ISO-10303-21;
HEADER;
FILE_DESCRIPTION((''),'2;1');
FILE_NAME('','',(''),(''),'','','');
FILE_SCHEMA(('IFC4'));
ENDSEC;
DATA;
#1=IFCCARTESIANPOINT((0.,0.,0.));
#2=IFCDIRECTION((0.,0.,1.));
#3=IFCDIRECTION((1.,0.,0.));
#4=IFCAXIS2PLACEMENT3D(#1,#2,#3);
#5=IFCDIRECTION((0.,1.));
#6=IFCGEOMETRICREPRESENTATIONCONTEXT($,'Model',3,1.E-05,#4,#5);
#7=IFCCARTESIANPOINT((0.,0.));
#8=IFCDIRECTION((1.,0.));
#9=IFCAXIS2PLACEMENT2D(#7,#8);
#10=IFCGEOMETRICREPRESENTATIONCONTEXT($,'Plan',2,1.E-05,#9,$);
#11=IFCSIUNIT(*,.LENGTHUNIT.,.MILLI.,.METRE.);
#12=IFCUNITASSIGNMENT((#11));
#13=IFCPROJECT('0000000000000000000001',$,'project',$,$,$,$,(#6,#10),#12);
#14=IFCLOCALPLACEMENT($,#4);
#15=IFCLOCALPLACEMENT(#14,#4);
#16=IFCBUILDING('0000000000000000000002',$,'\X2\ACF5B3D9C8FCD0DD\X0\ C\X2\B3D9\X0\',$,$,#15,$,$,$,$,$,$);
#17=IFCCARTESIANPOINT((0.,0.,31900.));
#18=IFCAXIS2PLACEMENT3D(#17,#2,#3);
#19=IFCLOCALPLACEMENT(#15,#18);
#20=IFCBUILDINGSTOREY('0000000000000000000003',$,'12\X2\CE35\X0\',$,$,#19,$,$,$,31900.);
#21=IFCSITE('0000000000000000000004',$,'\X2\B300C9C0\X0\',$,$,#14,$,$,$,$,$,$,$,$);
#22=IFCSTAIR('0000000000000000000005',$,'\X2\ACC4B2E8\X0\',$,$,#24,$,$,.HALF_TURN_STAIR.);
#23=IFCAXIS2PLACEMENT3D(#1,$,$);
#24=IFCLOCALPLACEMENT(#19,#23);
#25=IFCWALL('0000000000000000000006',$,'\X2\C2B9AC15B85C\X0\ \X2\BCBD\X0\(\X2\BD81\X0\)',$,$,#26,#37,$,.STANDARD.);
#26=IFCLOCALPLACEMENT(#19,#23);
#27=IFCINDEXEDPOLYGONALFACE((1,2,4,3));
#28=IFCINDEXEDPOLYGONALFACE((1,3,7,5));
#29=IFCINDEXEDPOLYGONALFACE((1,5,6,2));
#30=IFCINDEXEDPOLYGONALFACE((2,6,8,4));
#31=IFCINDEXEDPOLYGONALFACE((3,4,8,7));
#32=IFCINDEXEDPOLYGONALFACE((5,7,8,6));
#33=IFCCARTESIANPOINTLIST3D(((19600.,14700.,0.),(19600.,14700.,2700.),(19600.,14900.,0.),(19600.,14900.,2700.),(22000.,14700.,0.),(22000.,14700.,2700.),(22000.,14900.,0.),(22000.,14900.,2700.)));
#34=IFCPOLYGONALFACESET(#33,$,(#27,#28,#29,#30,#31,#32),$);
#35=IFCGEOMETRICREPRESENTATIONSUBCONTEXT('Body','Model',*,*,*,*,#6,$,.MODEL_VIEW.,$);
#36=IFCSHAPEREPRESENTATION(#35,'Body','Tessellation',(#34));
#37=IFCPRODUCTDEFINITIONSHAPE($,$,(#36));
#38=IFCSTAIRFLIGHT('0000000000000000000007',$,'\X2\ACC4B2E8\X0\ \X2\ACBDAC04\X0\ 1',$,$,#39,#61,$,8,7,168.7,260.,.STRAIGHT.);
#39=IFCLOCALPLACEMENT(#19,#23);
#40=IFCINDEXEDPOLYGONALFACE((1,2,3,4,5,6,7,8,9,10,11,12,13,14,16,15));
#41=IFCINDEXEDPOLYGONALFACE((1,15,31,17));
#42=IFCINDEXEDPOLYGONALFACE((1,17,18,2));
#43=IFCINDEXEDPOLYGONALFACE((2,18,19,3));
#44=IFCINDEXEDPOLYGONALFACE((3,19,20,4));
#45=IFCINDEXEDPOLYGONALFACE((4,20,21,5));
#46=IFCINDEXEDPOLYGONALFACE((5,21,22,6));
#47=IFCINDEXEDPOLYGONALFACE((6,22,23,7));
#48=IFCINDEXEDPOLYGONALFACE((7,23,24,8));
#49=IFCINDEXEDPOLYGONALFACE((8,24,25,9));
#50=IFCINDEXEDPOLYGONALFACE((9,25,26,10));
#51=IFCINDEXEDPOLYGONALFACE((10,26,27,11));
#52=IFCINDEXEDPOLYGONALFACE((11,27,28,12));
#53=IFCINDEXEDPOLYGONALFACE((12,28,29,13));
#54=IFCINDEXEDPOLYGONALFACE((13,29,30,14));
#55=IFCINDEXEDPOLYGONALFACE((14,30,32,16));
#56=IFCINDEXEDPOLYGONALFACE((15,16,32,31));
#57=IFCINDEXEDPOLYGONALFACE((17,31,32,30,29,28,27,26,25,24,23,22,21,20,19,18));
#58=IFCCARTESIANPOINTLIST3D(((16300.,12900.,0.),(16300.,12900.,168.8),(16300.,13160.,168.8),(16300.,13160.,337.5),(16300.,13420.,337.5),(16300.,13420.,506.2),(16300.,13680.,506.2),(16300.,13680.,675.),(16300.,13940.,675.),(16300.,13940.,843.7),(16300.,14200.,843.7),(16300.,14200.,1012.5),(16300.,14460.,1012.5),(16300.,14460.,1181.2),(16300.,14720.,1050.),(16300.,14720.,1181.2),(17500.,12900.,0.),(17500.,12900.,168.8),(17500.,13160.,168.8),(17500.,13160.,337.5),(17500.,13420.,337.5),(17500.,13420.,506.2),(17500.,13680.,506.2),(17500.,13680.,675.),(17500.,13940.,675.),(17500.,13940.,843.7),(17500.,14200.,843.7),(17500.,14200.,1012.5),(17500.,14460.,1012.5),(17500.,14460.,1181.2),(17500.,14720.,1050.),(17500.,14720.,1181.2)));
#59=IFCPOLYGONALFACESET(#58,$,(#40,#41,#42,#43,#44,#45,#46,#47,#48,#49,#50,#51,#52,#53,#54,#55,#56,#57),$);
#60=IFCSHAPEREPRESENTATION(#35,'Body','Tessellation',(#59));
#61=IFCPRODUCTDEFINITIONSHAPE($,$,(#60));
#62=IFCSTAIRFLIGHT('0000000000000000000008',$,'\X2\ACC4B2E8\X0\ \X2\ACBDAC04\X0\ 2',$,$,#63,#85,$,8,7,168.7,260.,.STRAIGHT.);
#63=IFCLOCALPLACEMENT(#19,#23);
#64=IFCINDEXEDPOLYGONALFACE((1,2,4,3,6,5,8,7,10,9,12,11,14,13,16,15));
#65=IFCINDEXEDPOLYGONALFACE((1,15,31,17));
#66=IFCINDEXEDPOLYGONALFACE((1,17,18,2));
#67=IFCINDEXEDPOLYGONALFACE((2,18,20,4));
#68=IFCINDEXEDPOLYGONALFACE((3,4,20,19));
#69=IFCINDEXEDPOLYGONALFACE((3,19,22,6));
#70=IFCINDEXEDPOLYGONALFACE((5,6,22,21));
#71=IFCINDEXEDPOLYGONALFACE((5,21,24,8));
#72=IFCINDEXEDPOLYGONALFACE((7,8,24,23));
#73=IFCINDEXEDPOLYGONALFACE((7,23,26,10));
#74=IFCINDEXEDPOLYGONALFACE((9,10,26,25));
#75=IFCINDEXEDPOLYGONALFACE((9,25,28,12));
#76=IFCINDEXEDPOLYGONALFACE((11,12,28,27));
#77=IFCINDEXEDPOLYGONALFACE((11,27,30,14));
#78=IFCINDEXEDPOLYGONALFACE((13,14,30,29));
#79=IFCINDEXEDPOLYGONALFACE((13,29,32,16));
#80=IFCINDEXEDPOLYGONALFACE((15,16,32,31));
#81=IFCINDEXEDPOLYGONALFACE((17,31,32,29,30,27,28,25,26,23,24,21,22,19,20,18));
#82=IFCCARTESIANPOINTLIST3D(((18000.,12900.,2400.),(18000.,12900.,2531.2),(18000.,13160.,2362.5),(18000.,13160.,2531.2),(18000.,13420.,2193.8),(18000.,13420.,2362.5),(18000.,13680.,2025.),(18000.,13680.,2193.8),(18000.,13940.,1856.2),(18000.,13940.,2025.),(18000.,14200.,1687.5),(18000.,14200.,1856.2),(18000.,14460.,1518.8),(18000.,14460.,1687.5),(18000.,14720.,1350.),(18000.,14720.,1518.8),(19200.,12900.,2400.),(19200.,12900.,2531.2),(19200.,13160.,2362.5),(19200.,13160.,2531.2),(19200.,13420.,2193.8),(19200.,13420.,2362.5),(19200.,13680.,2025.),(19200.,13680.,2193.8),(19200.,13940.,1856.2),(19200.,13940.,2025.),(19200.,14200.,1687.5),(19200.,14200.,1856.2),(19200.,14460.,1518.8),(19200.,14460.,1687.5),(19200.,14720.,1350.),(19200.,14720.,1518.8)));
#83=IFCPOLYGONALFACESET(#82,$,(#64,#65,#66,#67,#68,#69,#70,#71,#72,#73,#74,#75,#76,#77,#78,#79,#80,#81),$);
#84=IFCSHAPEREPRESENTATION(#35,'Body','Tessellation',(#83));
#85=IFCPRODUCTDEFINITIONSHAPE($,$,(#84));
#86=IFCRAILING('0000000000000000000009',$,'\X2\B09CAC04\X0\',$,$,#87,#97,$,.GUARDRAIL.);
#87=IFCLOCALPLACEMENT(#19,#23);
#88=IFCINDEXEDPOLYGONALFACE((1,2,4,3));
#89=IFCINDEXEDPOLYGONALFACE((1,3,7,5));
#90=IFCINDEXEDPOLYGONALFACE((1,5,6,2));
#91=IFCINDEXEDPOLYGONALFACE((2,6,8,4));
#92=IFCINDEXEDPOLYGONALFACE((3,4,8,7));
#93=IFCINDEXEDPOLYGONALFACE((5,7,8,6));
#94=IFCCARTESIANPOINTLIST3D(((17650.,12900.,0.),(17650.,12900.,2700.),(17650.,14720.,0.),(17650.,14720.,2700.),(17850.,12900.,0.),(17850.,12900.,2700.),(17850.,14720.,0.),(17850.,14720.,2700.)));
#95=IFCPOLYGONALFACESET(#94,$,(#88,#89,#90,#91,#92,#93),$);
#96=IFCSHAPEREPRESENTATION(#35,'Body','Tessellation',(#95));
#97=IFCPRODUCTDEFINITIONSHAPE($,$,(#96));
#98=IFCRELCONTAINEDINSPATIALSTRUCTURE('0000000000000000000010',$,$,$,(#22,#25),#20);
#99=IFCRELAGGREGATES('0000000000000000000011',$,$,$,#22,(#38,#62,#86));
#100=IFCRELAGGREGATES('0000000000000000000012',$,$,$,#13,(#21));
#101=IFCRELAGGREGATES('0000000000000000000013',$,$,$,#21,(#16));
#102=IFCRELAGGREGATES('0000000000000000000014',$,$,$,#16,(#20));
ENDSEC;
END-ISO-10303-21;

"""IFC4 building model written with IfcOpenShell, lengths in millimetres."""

from ifc_helpers import new_model, si_unit, direction, frame, origin_with_axes, origin_2d_with_axis, place, context, subcontext, project, spatial, polyline, outline, extrude, element, aggregate, save


model = new_model("IFC4")

# Units and contexts
model_context = context("Model", 3, precision=1e-05, world=origin_with_axes(), true_north=direction((0.0, 1.0)))
plan_context = context("Plan", 2, precision=1e-05, world=origin_2d_with_axis())
body_context = subcontext(model_context, "Body", "Model", "MODEL_VIEW")
ifc_project = project(units=[si_unit("LENGTHUNIT", "METRE", prefix="MILLI")], contexts=[model_context, plan_context])

# Site, building, storey
site_placement = place(None, origin_with_axes())
site = spatial("IfcSite", under=ifc_project, at=site_placement, Name="대지")
building_placement = place(site_placement, origin_with_axes())
building = spatial("IfcBuilding", under=site, at=building_placement, Name="공동주택 C동")
storey_placement = place(building_placement, frame((0.0, 0.0, 31900.0), z_axis=(0.0, 0.0, 1.0), x_axis=(1.0, 0.0, 0.0)))
storey = spatial("IfcBuildingStorey", under=building, at=storey_placement, Name="12층", Elevation=31900.0)

# Stair
stair_placement = place(storey_placement, origin_with_axes())
stair = element("IfcStair", 1, at=stair_placement, inside=storey, Name="계단", PredefinedType="HALF_TURN_STAIR")

# Wall
wall_1_placement = place(storey_placement, origin_with_axes())
element("IfcWall", 2, at=wall_1_placement, inside=storey, Name="승강로 벽(북)", PredefinedType="STANDARD", context=body_context, shape_type="SweptSolid", body=[
    extrude(outline(polyline([(19600.0, 14900.0), (22000.0, 14900.0), (22000.0, 14700.0), (19600.0, 14700.0), (19600.0, 14900.0)])), origin_with_axes(), (0.0, 0.0, 1.0), 2700.0),
])

# Stair flights
stair_flight_1_placement = place(stair_placement, origin_with_axes())
stair_flight_1 = element("IfcStairFlight", 3, at=stair_flight_1_placement, Name="계단 경간 1", NumberOfRisers=8, NumberOfTreads=7, PredefinedType="STRAIGHT", RiserHeight=168.7, TreadLength=260.0, context=body_context, shape_type="SweptSolid", body=[
    extrude(outline(polyline([(0.0, 0.0), (0.0, 168.7), (260.0, 168.7), (260.0, 337.5), (520.0, 337.5), (520.0, 506.2), (780.0, 506.2), (780.0, 675.0), (1040.0, 675.0), (1040.0, 843.7), (1300.0, 843.7), (1300.0, 1012.5), (1560.0, 1012.5), (1560.0, 1181.2), (1820.0, 1181.2), (1820.0, 1350.0), (1820.0, 1050.0), (0.0, 0.0)])), frame((16300.0, 12900.0, 0.0), z_axis=(1.0, 0.0, 0.0), x_axis=(0.0, 1.0, 0.0)), (0.0, 0.0, 1.0), 1200.0),
])
stair_flight_2_placement = place(stair_placement, origin_with_axes())
stair_flight_2 = element("IfcStairFlight", 4, at=stair_flight_2_placement, Name="계단 경간 2", NumberOfRisers=8, NumberOfTreads=7, PredefinedType="STRAIGHT", RiserHeight=168.7, TreadLength=260.0, context=body_context, shape_type="SweptSolid", body=[
    extrude(outline(polyline([(0.0, 0.0), (0.0, 168.7), (260.0, 168.7), (260.0, 337.5), (520.0, 337.5), (520.0, 506.2), (780.0, 506.2), (780.0, 675.0), (1040.0, 675.0), (1040.0, 843.7), (1300.0, 843.7), (1300.0, 1012.5), (1560.0, 1012.5), (1560.0, 1181.2), (1820.0, 1181.2), (1820.0, 1350.0), (1820.0, 1050.0), (0.0, 0.0)])), frame((19200.0, 14720.0, 1350.0), z_axis=(-1.0, 0.0, 0.0), x_axis=(0.0, -1.0, 0.0)), (0.0, 0.0, 1.0), 1200.0),
])

# Railing
railing_placement = place(stair_placement, origin_with_axes())
railing = element("IfcRailing", 5, at=railing_placement, Name="난간", PredefinedType="GUARDRAIL", context=body_context, shape_type="SweptSolid", body=[
    extrude(outline(polyline([(17650.0, 12900.0), (17850.0, 12900.0), (17850.0, 14720.0), (17650.0, 14720.0), (17650.0, 12900.0)])), origin_with_axes(), (0.0, 0.0, 1.0), 2700.0),
])
aggregate(stair, [stair_flight_1, stair_flight_2, railing])

save(model, "model.ifc")
